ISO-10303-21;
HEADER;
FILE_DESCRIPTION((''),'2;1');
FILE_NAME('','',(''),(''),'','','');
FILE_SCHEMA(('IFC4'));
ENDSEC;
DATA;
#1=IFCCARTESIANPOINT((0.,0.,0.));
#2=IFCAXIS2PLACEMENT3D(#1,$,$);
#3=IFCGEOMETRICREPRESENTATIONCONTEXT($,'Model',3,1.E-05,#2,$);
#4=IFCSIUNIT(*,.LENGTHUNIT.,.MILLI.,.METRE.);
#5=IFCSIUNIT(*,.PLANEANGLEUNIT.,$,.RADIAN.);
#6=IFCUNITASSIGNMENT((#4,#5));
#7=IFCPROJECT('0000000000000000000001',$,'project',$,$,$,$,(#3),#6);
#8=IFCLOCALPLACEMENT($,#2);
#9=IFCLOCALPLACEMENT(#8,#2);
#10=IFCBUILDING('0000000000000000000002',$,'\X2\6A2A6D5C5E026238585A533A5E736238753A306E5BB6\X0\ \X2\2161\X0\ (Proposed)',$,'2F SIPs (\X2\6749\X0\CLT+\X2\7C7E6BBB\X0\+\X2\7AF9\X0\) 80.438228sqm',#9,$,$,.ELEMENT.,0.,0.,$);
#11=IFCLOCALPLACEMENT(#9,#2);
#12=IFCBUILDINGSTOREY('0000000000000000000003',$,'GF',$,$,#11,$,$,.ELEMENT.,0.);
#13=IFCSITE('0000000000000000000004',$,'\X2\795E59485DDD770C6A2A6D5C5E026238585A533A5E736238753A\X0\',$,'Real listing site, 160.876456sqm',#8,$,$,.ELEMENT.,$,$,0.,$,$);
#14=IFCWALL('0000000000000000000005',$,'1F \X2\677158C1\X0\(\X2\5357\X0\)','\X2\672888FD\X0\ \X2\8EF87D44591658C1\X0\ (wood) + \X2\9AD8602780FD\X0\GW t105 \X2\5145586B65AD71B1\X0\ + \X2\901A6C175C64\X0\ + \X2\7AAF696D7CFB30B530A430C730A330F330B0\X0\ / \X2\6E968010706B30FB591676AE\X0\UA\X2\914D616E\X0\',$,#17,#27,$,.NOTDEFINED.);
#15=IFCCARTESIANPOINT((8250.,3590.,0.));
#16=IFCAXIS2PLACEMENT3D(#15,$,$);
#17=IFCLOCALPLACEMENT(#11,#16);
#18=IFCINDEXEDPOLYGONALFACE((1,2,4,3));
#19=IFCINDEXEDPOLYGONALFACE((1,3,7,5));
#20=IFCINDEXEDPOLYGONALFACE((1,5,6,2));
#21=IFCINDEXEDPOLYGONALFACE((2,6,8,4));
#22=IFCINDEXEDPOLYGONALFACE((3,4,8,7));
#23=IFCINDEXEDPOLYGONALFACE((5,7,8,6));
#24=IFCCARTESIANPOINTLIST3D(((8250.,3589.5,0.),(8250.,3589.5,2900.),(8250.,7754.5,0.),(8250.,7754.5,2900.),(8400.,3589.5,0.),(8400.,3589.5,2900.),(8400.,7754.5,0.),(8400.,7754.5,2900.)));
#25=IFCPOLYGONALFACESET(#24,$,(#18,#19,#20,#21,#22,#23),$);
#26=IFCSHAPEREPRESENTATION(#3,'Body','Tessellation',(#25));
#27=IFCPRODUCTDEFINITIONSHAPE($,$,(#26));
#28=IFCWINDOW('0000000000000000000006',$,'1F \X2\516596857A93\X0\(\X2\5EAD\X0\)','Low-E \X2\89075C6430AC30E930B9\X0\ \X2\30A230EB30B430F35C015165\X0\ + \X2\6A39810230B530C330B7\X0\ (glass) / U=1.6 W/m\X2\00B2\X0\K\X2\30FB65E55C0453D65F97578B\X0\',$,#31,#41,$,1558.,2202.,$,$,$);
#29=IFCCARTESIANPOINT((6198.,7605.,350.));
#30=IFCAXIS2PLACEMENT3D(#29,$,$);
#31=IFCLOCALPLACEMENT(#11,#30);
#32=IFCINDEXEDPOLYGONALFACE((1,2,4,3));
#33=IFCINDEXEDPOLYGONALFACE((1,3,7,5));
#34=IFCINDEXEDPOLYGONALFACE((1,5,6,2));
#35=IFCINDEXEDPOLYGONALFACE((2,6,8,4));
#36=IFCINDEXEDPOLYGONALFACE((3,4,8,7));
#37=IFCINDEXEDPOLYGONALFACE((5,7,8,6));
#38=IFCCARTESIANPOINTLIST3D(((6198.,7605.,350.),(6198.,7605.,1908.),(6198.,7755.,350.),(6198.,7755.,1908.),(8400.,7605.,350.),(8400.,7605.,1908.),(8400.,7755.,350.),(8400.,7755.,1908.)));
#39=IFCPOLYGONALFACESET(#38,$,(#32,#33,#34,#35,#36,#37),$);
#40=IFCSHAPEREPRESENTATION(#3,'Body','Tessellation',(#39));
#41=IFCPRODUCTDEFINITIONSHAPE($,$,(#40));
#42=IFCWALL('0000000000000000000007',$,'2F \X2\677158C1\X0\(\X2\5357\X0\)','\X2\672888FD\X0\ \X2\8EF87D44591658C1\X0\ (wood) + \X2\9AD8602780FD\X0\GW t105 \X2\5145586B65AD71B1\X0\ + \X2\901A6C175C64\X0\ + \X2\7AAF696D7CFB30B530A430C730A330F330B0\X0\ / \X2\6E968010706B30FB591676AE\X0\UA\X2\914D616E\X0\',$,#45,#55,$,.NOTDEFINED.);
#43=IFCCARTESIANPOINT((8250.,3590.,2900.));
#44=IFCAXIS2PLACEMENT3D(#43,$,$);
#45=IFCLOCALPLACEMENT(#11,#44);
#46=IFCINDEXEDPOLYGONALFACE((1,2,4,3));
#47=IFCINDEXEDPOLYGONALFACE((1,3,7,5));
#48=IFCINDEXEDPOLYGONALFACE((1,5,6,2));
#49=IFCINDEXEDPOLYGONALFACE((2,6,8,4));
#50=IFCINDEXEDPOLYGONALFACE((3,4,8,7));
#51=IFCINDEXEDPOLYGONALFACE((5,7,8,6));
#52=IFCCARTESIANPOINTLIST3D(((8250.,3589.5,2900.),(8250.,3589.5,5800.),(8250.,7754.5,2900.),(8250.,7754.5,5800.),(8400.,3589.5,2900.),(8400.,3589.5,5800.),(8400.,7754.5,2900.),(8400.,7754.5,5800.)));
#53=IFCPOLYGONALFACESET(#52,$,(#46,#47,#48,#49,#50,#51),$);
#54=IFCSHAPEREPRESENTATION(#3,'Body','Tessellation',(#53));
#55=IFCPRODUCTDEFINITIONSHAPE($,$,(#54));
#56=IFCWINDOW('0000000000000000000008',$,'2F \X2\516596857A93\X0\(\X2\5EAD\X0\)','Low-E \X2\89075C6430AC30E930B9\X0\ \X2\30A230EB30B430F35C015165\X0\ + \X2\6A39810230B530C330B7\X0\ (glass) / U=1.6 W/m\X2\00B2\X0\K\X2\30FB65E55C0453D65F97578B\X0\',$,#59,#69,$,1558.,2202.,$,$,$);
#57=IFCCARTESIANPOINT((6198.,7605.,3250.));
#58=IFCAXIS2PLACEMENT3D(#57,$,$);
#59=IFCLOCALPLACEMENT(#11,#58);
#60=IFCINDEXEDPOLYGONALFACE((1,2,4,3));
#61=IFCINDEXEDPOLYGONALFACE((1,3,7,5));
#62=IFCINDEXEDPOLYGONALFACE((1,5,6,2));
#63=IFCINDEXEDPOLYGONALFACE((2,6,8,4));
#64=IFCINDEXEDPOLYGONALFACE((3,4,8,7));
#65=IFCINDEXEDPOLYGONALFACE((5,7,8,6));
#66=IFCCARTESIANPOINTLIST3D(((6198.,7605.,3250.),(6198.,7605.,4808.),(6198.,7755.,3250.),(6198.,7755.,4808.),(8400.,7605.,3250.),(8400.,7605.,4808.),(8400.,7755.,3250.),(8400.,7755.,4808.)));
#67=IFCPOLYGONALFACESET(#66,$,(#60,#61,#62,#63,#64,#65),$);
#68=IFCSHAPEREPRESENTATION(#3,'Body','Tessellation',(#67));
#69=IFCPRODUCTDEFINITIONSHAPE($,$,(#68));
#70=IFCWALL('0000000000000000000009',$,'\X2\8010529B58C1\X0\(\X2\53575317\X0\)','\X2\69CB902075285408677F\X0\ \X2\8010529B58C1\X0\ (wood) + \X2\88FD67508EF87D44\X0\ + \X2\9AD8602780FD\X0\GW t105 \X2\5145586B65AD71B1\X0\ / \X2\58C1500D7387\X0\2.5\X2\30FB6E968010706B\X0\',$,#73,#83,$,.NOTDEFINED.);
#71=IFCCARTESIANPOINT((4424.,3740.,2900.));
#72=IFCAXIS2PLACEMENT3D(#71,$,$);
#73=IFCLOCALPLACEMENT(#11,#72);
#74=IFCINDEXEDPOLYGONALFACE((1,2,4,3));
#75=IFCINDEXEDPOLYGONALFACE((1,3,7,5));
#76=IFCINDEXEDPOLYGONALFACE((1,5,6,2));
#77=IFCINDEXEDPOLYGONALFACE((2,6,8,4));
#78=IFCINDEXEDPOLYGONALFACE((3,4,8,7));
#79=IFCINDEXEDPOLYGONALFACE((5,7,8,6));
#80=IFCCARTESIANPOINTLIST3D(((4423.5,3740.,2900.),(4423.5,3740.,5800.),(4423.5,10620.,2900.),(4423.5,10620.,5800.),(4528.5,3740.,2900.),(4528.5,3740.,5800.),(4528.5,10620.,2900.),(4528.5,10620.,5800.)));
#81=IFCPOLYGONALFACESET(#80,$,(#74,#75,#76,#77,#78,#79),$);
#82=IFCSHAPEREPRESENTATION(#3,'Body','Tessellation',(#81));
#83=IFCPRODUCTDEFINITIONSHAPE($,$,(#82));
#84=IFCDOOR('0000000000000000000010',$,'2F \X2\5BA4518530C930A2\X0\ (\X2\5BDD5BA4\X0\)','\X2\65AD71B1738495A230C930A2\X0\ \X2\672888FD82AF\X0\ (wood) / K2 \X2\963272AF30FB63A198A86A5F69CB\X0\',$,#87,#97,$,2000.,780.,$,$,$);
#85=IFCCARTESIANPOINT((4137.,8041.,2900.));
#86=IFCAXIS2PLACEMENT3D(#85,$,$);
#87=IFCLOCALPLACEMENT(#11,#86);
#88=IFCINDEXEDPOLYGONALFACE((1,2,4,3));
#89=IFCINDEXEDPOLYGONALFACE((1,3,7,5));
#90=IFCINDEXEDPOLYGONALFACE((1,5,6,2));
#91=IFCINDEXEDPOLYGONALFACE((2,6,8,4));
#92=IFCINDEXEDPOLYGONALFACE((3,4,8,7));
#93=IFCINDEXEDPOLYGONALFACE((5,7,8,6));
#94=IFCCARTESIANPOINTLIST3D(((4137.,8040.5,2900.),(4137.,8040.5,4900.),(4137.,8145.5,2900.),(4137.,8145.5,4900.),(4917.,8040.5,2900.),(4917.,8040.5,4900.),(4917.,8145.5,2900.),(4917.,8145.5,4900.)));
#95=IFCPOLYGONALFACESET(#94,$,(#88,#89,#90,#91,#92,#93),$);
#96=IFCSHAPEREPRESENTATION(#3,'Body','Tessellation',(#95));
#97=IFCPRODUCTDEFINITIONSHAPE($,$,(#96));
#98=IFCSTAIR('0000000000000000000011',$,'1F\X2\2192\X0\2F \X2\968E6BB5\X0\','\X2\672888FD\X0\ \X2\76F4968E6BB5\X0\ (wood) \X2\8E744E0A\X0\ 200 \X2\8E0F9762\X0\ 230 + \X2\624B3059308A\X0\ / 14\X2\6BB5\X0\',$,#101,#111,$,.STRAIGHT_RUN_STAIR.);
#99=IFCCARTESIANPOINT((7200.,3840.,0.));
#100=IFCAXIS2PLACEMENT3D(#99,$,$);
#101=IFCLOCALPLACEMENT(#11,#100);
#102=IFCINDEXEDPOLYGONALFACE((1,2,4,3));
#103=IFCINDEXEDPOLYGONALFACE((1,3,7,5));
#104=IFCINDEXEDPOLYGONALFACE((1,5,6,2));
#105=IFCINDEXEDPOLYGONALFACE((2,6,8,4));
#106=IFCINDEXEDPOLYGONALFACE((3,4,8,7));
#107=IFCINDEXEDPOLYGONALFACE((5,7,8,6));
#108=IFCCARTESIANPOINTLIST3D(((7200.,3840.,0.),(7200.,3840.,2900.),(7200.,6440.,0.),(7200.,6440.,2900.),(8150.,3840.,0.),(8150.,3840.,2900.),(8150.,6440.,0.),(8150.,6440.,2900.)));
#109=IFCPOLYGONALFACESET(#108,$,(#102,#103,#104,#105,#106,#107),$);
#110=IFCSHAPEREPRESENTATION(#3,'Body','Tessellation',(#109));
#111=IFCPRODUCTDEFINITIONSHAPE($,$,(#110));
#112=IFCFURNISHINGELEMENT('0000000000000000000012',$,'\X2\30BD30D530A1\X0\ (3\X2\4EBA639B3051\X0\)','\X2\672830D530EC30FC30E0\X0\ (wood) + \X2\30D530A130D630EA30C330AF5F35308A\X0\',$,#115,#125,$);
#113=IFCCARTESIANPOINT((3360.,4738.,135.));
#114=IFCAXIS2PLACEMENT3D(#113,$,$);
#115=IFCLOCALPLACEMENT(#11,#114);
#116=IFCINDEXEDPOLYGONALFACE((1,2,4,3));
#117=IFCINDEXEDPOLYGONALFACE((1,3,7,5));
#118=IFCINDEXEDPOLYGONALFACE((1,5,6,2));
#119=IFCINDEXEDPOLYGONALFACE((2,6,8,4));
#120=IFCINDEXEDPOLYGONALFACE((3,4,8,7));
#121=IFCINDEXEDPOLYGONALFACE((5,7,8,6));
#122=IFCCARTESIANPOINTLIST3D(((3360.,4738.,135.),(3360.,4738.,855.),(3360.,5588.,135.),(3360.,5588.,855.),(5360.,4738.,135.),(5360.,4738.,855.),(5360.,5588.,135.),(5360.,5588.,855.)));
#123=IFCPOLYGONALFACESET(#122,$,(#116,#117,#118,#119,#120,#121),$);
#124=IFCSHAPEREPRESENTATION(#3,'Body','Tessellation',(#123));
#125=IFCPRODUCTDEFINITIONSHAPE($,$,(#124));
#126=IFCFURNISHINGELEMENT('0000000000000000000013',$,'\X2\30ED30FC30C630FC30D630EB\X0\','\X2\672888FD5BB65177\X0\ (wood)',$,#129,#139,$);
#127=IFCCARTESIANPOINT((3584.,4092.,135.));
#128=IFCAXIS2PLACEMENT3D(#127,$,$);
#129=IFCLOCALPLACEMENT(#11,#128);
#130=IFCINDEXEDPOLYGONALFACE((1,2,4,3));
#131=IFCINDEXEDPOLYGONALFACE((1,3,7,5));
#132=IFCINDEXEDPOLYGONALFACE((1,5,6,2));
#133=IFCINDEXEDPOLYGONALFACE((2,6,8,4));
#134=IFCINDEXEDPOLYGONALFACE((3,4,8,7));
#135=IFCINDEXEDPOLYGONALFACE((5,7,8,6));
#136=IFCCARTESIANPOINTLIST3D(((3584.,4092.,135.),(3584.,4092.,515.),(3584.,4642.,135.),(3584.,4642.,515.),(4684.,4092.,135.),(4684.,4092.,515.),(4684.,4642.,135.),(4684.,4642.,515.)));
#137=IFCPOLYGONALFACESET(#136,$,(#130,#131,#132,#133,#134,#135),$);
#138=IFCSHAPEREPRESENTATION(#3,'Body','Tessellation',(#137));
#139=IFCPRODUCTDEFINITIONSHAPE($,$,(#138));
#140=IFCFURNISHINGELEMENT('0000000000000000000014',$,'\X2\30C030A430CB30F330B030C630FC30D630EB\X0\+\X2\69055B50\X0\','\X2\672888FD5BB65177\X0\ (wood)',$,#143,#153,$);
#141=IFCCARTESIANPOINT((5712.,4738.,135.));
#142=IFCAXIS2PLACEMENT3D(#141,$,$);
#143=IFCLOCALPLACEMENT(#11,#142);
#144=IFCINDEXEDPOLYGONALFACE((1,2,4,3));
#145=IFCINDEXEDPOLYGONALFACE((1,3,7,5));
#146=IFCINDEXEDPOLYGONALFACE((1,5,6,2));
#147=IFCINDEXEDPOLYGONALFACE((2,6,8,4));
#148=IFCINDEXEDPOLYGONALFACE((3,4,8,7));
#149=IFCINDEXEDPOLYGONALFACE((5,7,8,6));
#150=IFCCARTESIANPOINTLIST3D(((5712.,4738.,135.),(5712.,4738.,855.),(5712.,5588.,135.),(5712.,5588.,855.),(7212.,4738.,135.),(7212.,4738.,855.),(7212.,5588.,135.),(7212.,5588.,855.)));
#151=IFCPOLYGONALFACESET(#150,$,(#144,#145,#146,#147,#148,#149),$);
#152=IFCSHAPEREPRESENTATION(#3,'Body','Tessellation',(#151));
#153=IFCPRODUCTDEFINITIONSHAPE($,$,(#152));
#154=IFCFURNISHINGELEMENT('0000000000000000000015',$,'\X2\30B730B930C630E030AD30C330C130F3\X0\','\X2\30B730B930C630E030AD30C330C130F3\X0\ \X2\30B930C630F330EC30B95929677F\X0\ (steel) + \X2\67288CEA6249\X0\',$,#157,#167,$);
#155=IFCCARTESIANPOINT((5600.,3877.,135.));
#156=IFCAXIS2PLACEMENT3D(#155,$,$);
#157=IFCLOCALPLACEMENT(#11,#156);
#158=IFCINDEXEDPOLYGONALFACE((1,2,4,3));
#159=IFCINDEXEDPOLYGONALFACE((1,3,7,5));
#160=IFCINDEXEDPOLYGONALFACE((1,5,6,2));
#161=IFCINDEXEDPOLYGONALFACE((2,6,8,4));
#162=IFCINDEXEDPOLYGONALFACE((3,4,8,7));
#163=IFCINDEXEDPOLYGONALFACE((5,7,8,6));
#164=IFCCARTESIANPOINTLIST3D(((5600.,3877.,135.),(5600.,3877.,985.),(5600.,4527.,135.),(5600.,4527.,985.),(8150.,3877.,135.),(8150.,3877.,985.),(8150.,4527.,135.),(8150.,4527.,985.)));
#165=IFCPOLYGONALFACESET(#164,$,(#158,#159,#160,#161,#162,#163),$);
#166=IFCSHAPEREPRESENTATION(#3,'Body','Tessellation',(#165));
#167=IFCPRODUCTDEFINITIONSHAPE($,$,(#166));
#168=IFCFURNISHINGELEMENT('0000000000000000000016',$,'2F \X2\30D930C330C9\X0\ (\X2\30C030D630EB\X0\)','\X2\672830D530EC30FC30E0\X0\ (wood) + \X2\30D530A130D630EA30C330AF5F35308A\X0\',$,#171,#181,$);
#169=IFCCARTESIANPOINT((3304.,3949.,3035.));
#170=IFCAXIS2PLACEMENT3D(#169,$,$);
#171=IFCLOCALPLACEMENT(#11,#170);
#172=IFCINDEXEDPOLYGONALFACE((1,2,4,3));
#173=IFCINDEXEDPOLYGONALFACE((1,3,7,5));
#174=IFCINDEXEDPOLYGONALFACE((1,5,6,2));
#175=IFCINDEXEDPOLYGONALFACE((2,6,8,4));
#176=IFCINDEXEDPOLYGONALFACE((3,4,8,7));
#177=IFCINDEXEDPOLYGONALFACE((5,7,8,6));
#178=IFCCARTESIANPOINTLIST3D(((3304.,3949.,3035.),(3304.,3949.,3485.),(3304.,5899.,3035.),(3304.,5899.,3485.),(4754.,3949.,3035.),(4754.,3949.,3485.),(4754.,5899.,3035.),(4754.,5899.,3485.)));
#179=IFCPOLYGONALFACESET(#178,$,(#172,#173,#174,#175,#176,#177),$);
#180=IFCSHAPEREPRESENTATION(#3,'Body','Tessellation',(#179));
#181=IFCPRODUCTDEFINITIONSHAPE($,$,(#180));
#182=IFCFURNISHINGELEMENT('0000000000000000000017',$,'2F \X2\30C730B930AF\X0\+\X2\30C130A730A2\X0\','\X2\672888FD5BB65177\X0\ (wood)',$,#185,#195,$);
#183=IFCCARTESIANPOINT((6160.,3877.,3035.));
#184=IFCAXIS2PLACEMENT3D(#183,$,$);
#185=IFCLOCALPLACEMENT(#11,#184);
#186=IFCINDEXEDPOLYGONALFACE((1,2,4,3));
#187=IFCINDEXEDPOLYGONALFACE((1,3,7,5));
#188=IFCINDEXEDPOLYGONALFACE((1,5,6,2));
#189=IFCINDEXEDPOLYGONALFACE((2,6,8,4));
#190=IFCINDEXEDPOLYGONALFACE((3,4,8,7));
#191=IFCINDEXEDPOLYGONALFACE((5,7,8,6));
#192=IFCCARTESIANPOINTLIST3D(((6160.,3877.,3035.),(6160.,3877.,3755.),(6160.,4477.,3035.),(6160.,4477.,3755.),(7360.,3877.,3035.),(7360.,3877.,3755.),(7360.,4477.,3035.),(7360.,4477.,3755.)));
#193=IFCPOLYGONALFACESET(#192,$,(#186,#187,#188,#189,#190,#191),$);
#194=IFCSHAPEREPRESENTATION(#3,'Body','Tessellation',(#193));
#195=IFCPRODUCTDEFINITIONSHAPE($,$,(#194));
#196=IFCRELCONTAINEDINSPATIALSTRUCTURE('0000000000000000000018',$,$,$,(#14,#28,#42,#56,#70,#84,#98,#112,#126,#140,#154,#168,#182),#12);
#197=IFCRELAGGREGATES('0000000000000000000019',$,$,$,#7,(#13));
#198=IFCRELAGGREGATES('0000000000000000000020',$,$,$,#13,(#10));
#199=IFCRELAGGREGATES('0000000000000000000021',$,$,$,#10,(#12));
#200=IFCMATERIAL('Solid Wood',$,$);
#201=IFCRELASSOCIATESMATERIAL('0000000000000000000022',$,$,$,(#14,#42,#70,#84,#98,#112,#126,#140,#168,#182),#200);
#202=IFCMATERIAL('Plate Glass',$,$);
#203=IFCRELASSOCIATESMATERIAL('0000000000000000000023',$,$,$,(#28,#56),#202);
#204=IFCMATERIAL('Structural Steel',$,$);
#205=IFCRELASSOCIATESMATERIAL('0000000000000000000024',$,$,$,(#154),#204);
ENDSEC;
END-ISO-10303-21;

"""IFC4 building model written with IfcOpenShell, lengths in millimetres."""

from ifc_helpers import new_model, si_unit, frame, frame_2d, origin, place, context, project, spatial, rectangle, extrude, material, element, fill, save


model = new_model("IFC4")

# Units and contexts
model_context = context("Model", 3, precision=1e-05, world=origin())
ifc_project = project(units=[si_unit("LENGTHUNIT", "METRE", prefix="MILLI"), si_unit("PLANEANGLEUNIT", "RADIAN")], contexts=[model_context])

# Site, building, storey
site_placement = place(None, origin())
site = spatial("IfcSite", under=ifc_project, at=site_placement, Name="神奈川県横浜市戸塚区平戸町", ObjectType="Real listing site, 160.876456sqm", CompositionType="ELEMENT", RefElevation=0.0)
building_placement = place(site_placement, origin())
building = spatial("IfcBuilding", under=site, at=building_placement, Name="横浜市戸塚区平戸町の家 Ⅱ (Proposed)", ObjectType="2F SIPs (杉CLT+籾殻+竹) 80.438228sqm", CompositionType="ELEMENT", ElevationOfRefHeight=0.0, ElevationOfTerrain=0.0)
storey_placement = place(building_placement, origin())
storey = spatial("IfcBuildingStorey", under=building, at=storey_placement, Name="GF", CompositionType="ELEMENT", Elevation=0.0)

# Wall, opening, window
ifc_material_1 = material(Name="Solid Wood")
wall_1_placement = place(storey_placement, frame((8250.0, 3590.0, 0.0)))
wall_1 = element("IfcWall", 1, at=wall_1_placement, inside=storey, material=ifc_material_1, Name="1F 東壁(南)", Description="木製 軸組外壁 (wood) + 高性能GW t105 充填断熱 + 通気層 + 窯業系サイディング / 準耐火・外皮UA配慮", PredefinedType="NOTDEFINED", context=model_context, shape_type="SweptSolid", body=[
    extrude(rectangle(XDim=150.0, YDim=4165.0, at=frame_2d((75.0, 2082.0))), frame((8250.0, 3590.0, 0.0)), (0.0, 0.0, 1.0), 2900.0),
])
opening_1_placement = place(storey_placement, frame((6198.0, 7605.0, 350.0)))
opening_1 = element("IfcOpeningElement", 2, at=opening_1_placement, cuts=wall_1, PredefinedType="NOTDEFINED", context=model_context, shape_type="SweptSolid", body=[
    extrude(rectangle(XDim=2202.0, YDim=150.0, at=frame_2d((1101.0, 75.0))), frame((6198.0, 7605.0, 350.0)), (0.0, 0.0, 1.0), 1558.0),
])
ifc_material_2 = material(Name="Plate Glass")
window_1_placement = place(storey_placement, frame((6198.0, 7605.0, 350.0)))
window_1 = element("IfcWindow", 3, at=window_1_placement, inside=storey, material=ifc_material_2, Name="1F 入隅窓(庭)", Description="Low-E 複層ガラス アルゴン封入 + 樹脂サッシ (glass) / U=1.6 W/m²K・日射取得型", OverallHeight=1558.0, OverallWidth=2202.0, context=model_context, shape_type="SweptSolid", body=[
    extrude(rectangle(XDim=2202.0, YDim=150.0, at=frame_2d((1101.0, 75.0))), frame((6198.0, 7605.0, 350.0)), (0.0, 0.0, 1.0), 1558.0),
])
fill(opening_1, window_1)

# Wall, opening, window
wall_2_placement = place(storey_placement, frame((8250.0, 3590.0, 2900.0)))
wall_2 = element("IfcWall", 4, at=wall_2_placement, inside=storey, material=ifc_material_1, Name="2F 東壁(南)", Description="木製 軸組外壁 (wood) + 高性能GW t105 充填断熱 + 通気層 + 窯業系サイディング / 準耐火・外皮UA配慮", PredefinedType="NOTDEFINED", context=model_context, shape_type="SweptSolid", body=[
    extrude(rectangle(XDim=150.0, YDim=4165.0, at=frame_2d((75.0, 2082.0))), frame((8250.0, 3590.0, 2900.0)), (0.0, 0.0, 1.0), 2900.0),
])
opening_2_placement = place(storey_placement, frame((6198.0, 7605.0, 3250.0)))
opening_2 = element("IfcOpeningElement", 5, at=opening_2_placement, cuts=wall_2, PredefinedType="NOTDEFINED", context=model_context, shape_type="SweptSolid", body=[
    extrude(rectangle(XDim=2202.0, YDim=150.0, at=frame_2d((1101.0, 75.0))), frame((6198.0, 7605.0, 3250.0)), (0.0, 0.0, 1.0), 1558.0),
])
window_2_placement = place(storey_placement, frame((6198.0, 7605.0, 3250.0)))
window_2 = element("IfcWindow", 6, at=window_2_placement, inside=storey, material=ifc_material_2, Name="2F 入隅窓(庭)", Description="Low-E 複層ガラス アルゴン封入 + 樹脂サッシ (glass) / U=1.6 W/m²K・日射取得型", OverallHeight=1558.0, OverallWidth=2202.0, context=model_context, shape_type="SweptSolid", body=[
    extrude(rectangle(XDim=2202.0, YDim=150.0, at=frame_2d((1101.0, 75.0))), frame((6198.0, 7605.0, 3250.0)), (0.0, 0.0, 1.0), 1558.0),
])
fill(opening_2, window_2)

# Wall, opening, door
wall_3_placement = place(storey_placement, frame((4424.0, 3740.0, 2900.0)))
wall_3 = element("IfcWall", 7, at=wall_3_placement, inside=storey, material=ifc_material_1, Name="耐力壁(南北)", Description="構造用合板 耐力壁 (wood) + 製材軸組 + 高性能GW t105 充填断熱 / 壁倍率2.5・準耐火", PredefinedType="NOTDEFINED", context=model_context, shape_type="SweptSolid", body=[
    extrude(rectangle(XDim=105.0, YDim=6880.0, at=frame_2d((52.0, 3440.0))), frame((4424.0, 3740.0, 2900.0)), (0.0, 0.0, 1.0), 2900.0),
])
opening_3_placement = place(storey_placement, frame((4137.0, 8041.0, 2900.0)))
opening_3 = element("IfcOpeningElement", 8, at=opening_3_placement, cuts=wall_3, PredefinedType="NOTDEFINED", context=model_context, shape_type="SweptSolid", body=[
    extrude(rectangle(XDim=780.0, YDim=105.0, at=frame_2d((390.0, 52.0))), frame((4137.0, 8041.0, 2900.0)), (0.0, 0.0, 1.0), 2000.0),
])
door_1_placement = place(storey_placement, frame((4137.0, 8041.0, 2900.0)))
door_1 = element("IfcDoor", 9, at=door_1_placement, inside=storey, material=ifc_material_1, Name="2F 室内ドア (寝室)", Description="断熱玄関ドア 木製芯 (wood) / K2 防犯・採風機構", OverallHeight=2000.0, OverallWidth=780.0, context=model_context, shape_type="SweptSolid", body=[
    extrude(rectangle(XDim=780.0, YDim=105.0, at=frame_2d((390.0, 52.0))), frame((4137.0, 8041.0, 2900.0)), (0.0, 0.0, 1.0), 2000.0),
])
fill(opening_3, door_1)

# Stair
stair_placement = place(storey_placement, frame((7200.0, 3840.0, 0.0)))
element("IfcStair", 10, at=stair_placement, inside=storey, material=ifc_material_1, Name="1F→2F 階段", Description="木製 直階段 (wood) 蹴上 200 踏面 230 + 手すり / 14段", PredefinedType="STRAIGHT_RUN_STAIR", context=model_context, shape_type="SweptSolid", body=[
    extrude(rectangle(XDim=950.0, YDim=2600.0, at=frame_2d((475.0, 1300.0))), frame((7200.0, 3840.0, 0.0)), (0.0, 0.0, 1.0), 2900.0),
])

# Furnishing elements
furnishing_1_placement = place(storey_placement, frame((3360.0, 4738.0, 135.0)))
element("IfcFurnishingElement", 11, at=furnishing_1_placement, inside=storey, material=ifc_material_1, Name="ソファ (3人掛け)", Description="木フレーム (wood) + ファブリック張り", context=model_context, shape_type="SweptSolid", body=[
    extrude(rectangle(XDim=2000.0, YDim=850.0, at=frame_2d((1000.0, 425.0))), frame((3360.0, 4738.0, 135.0)), (0.0, 0.0, 1.0), 720.0),
])
furnishing_2_placement = place(storey_placement, frame((3584.0, 4092.0, 135.0)))
element("IfcFurnishingElement", 12, at=furnishing_2_placement, inside=storey, material=ifc_material_1, Name="ローテーブル", Description="木製家具 (wood)", context=model_context, shape_type="SweptSolid", body=[
    extrude(rectangle(XDim=1100.0, YDim=550.0, at=frame_2d((550.0, 275.0))), frame((3584.0, 4092.0, 135.0)), (0.0, 0.0, 1.0), 380.0),
])
furnishing_3_placement = place(storey_placement, frame((5712.0, 4738.0, 135.0)))
element("IfcFurnishingElement", 13, at=furnishing_3_placement, inside=storey, material=ifc_material_1, Name="ダイニングテーブル+椅子", Description="木製家具 (wood)", context=model_context, shape_type="SweptSolid", body=[
    extrude(rectangle(XDim=1500.0, YDim=850.0, at=frame_2d((750.0, 425.0))), frame((5712.0, 4738.0, 135.0)), (0.0, 0.0, 1.0), 720.0),
])
ifc_material_3 = material(Name="Structural Steel")
furnishing_4_placement = place(storey_placement, frame((5600.0, 3877.0, 135.0)))
element("IfcFurnishingElement", 14, at=furnishing_4_placement, inside=storey, material=ifc_material_3, Name="システムキッチン", Description="システムキッチン ステンレス天板 (steel) + 木質扉", context=model_context, shape_type="SweptSolid", body=[
    extrude(rectangle(XDim=2550.0, YDim=650.0, at=frame_2d((1275.0, 325.0))), frame((5600.0, 3877.0, 135.0)), (0.0, 0.0, 1.0), 850.0),
])
furnishing_5_placement = place(storey_placement, frame((3304.0, 3949.0, 3035.0)))
element("IfcFurnishingElement", 15, at=furnishing_5_placement, inside=storey, material=ifc_material_1, Name="2F ベッド (ダブル)", Description="木フレーム (wood) + ファブリック張り", context=model_context, shape_type="SweptSolid", body=[
    extrude(rectangle(XDim=1450.0, YDim=1950.0, at=frame_2d((725.0, 975.0))), frame((3304.0, 3949.0, 3035.0)), (0.0, 0.0, 1.0), 450.0),
])
furnishing_6_placement = place(storey_placement, frame((6160.0, 3877.0, 3035.0)))
element("IfcFurnishingElement", 16, at=furnishing_6_placement, inside=storey, material=ifc_material_1, Name="2F デスク+チェア", Description="木製家具 (wood)", context=model_context, shape_type="SweptSolid", body=[
    extrude(rectangle(XDim=1200.0, YDim=600.0, at=frame_2d((600.0, 300.0))), frame((6160.0, 3877.0, 3035.0)), (0.0, 0.0, 1.0), 720.0),
])

save(model, "model.ifc")
